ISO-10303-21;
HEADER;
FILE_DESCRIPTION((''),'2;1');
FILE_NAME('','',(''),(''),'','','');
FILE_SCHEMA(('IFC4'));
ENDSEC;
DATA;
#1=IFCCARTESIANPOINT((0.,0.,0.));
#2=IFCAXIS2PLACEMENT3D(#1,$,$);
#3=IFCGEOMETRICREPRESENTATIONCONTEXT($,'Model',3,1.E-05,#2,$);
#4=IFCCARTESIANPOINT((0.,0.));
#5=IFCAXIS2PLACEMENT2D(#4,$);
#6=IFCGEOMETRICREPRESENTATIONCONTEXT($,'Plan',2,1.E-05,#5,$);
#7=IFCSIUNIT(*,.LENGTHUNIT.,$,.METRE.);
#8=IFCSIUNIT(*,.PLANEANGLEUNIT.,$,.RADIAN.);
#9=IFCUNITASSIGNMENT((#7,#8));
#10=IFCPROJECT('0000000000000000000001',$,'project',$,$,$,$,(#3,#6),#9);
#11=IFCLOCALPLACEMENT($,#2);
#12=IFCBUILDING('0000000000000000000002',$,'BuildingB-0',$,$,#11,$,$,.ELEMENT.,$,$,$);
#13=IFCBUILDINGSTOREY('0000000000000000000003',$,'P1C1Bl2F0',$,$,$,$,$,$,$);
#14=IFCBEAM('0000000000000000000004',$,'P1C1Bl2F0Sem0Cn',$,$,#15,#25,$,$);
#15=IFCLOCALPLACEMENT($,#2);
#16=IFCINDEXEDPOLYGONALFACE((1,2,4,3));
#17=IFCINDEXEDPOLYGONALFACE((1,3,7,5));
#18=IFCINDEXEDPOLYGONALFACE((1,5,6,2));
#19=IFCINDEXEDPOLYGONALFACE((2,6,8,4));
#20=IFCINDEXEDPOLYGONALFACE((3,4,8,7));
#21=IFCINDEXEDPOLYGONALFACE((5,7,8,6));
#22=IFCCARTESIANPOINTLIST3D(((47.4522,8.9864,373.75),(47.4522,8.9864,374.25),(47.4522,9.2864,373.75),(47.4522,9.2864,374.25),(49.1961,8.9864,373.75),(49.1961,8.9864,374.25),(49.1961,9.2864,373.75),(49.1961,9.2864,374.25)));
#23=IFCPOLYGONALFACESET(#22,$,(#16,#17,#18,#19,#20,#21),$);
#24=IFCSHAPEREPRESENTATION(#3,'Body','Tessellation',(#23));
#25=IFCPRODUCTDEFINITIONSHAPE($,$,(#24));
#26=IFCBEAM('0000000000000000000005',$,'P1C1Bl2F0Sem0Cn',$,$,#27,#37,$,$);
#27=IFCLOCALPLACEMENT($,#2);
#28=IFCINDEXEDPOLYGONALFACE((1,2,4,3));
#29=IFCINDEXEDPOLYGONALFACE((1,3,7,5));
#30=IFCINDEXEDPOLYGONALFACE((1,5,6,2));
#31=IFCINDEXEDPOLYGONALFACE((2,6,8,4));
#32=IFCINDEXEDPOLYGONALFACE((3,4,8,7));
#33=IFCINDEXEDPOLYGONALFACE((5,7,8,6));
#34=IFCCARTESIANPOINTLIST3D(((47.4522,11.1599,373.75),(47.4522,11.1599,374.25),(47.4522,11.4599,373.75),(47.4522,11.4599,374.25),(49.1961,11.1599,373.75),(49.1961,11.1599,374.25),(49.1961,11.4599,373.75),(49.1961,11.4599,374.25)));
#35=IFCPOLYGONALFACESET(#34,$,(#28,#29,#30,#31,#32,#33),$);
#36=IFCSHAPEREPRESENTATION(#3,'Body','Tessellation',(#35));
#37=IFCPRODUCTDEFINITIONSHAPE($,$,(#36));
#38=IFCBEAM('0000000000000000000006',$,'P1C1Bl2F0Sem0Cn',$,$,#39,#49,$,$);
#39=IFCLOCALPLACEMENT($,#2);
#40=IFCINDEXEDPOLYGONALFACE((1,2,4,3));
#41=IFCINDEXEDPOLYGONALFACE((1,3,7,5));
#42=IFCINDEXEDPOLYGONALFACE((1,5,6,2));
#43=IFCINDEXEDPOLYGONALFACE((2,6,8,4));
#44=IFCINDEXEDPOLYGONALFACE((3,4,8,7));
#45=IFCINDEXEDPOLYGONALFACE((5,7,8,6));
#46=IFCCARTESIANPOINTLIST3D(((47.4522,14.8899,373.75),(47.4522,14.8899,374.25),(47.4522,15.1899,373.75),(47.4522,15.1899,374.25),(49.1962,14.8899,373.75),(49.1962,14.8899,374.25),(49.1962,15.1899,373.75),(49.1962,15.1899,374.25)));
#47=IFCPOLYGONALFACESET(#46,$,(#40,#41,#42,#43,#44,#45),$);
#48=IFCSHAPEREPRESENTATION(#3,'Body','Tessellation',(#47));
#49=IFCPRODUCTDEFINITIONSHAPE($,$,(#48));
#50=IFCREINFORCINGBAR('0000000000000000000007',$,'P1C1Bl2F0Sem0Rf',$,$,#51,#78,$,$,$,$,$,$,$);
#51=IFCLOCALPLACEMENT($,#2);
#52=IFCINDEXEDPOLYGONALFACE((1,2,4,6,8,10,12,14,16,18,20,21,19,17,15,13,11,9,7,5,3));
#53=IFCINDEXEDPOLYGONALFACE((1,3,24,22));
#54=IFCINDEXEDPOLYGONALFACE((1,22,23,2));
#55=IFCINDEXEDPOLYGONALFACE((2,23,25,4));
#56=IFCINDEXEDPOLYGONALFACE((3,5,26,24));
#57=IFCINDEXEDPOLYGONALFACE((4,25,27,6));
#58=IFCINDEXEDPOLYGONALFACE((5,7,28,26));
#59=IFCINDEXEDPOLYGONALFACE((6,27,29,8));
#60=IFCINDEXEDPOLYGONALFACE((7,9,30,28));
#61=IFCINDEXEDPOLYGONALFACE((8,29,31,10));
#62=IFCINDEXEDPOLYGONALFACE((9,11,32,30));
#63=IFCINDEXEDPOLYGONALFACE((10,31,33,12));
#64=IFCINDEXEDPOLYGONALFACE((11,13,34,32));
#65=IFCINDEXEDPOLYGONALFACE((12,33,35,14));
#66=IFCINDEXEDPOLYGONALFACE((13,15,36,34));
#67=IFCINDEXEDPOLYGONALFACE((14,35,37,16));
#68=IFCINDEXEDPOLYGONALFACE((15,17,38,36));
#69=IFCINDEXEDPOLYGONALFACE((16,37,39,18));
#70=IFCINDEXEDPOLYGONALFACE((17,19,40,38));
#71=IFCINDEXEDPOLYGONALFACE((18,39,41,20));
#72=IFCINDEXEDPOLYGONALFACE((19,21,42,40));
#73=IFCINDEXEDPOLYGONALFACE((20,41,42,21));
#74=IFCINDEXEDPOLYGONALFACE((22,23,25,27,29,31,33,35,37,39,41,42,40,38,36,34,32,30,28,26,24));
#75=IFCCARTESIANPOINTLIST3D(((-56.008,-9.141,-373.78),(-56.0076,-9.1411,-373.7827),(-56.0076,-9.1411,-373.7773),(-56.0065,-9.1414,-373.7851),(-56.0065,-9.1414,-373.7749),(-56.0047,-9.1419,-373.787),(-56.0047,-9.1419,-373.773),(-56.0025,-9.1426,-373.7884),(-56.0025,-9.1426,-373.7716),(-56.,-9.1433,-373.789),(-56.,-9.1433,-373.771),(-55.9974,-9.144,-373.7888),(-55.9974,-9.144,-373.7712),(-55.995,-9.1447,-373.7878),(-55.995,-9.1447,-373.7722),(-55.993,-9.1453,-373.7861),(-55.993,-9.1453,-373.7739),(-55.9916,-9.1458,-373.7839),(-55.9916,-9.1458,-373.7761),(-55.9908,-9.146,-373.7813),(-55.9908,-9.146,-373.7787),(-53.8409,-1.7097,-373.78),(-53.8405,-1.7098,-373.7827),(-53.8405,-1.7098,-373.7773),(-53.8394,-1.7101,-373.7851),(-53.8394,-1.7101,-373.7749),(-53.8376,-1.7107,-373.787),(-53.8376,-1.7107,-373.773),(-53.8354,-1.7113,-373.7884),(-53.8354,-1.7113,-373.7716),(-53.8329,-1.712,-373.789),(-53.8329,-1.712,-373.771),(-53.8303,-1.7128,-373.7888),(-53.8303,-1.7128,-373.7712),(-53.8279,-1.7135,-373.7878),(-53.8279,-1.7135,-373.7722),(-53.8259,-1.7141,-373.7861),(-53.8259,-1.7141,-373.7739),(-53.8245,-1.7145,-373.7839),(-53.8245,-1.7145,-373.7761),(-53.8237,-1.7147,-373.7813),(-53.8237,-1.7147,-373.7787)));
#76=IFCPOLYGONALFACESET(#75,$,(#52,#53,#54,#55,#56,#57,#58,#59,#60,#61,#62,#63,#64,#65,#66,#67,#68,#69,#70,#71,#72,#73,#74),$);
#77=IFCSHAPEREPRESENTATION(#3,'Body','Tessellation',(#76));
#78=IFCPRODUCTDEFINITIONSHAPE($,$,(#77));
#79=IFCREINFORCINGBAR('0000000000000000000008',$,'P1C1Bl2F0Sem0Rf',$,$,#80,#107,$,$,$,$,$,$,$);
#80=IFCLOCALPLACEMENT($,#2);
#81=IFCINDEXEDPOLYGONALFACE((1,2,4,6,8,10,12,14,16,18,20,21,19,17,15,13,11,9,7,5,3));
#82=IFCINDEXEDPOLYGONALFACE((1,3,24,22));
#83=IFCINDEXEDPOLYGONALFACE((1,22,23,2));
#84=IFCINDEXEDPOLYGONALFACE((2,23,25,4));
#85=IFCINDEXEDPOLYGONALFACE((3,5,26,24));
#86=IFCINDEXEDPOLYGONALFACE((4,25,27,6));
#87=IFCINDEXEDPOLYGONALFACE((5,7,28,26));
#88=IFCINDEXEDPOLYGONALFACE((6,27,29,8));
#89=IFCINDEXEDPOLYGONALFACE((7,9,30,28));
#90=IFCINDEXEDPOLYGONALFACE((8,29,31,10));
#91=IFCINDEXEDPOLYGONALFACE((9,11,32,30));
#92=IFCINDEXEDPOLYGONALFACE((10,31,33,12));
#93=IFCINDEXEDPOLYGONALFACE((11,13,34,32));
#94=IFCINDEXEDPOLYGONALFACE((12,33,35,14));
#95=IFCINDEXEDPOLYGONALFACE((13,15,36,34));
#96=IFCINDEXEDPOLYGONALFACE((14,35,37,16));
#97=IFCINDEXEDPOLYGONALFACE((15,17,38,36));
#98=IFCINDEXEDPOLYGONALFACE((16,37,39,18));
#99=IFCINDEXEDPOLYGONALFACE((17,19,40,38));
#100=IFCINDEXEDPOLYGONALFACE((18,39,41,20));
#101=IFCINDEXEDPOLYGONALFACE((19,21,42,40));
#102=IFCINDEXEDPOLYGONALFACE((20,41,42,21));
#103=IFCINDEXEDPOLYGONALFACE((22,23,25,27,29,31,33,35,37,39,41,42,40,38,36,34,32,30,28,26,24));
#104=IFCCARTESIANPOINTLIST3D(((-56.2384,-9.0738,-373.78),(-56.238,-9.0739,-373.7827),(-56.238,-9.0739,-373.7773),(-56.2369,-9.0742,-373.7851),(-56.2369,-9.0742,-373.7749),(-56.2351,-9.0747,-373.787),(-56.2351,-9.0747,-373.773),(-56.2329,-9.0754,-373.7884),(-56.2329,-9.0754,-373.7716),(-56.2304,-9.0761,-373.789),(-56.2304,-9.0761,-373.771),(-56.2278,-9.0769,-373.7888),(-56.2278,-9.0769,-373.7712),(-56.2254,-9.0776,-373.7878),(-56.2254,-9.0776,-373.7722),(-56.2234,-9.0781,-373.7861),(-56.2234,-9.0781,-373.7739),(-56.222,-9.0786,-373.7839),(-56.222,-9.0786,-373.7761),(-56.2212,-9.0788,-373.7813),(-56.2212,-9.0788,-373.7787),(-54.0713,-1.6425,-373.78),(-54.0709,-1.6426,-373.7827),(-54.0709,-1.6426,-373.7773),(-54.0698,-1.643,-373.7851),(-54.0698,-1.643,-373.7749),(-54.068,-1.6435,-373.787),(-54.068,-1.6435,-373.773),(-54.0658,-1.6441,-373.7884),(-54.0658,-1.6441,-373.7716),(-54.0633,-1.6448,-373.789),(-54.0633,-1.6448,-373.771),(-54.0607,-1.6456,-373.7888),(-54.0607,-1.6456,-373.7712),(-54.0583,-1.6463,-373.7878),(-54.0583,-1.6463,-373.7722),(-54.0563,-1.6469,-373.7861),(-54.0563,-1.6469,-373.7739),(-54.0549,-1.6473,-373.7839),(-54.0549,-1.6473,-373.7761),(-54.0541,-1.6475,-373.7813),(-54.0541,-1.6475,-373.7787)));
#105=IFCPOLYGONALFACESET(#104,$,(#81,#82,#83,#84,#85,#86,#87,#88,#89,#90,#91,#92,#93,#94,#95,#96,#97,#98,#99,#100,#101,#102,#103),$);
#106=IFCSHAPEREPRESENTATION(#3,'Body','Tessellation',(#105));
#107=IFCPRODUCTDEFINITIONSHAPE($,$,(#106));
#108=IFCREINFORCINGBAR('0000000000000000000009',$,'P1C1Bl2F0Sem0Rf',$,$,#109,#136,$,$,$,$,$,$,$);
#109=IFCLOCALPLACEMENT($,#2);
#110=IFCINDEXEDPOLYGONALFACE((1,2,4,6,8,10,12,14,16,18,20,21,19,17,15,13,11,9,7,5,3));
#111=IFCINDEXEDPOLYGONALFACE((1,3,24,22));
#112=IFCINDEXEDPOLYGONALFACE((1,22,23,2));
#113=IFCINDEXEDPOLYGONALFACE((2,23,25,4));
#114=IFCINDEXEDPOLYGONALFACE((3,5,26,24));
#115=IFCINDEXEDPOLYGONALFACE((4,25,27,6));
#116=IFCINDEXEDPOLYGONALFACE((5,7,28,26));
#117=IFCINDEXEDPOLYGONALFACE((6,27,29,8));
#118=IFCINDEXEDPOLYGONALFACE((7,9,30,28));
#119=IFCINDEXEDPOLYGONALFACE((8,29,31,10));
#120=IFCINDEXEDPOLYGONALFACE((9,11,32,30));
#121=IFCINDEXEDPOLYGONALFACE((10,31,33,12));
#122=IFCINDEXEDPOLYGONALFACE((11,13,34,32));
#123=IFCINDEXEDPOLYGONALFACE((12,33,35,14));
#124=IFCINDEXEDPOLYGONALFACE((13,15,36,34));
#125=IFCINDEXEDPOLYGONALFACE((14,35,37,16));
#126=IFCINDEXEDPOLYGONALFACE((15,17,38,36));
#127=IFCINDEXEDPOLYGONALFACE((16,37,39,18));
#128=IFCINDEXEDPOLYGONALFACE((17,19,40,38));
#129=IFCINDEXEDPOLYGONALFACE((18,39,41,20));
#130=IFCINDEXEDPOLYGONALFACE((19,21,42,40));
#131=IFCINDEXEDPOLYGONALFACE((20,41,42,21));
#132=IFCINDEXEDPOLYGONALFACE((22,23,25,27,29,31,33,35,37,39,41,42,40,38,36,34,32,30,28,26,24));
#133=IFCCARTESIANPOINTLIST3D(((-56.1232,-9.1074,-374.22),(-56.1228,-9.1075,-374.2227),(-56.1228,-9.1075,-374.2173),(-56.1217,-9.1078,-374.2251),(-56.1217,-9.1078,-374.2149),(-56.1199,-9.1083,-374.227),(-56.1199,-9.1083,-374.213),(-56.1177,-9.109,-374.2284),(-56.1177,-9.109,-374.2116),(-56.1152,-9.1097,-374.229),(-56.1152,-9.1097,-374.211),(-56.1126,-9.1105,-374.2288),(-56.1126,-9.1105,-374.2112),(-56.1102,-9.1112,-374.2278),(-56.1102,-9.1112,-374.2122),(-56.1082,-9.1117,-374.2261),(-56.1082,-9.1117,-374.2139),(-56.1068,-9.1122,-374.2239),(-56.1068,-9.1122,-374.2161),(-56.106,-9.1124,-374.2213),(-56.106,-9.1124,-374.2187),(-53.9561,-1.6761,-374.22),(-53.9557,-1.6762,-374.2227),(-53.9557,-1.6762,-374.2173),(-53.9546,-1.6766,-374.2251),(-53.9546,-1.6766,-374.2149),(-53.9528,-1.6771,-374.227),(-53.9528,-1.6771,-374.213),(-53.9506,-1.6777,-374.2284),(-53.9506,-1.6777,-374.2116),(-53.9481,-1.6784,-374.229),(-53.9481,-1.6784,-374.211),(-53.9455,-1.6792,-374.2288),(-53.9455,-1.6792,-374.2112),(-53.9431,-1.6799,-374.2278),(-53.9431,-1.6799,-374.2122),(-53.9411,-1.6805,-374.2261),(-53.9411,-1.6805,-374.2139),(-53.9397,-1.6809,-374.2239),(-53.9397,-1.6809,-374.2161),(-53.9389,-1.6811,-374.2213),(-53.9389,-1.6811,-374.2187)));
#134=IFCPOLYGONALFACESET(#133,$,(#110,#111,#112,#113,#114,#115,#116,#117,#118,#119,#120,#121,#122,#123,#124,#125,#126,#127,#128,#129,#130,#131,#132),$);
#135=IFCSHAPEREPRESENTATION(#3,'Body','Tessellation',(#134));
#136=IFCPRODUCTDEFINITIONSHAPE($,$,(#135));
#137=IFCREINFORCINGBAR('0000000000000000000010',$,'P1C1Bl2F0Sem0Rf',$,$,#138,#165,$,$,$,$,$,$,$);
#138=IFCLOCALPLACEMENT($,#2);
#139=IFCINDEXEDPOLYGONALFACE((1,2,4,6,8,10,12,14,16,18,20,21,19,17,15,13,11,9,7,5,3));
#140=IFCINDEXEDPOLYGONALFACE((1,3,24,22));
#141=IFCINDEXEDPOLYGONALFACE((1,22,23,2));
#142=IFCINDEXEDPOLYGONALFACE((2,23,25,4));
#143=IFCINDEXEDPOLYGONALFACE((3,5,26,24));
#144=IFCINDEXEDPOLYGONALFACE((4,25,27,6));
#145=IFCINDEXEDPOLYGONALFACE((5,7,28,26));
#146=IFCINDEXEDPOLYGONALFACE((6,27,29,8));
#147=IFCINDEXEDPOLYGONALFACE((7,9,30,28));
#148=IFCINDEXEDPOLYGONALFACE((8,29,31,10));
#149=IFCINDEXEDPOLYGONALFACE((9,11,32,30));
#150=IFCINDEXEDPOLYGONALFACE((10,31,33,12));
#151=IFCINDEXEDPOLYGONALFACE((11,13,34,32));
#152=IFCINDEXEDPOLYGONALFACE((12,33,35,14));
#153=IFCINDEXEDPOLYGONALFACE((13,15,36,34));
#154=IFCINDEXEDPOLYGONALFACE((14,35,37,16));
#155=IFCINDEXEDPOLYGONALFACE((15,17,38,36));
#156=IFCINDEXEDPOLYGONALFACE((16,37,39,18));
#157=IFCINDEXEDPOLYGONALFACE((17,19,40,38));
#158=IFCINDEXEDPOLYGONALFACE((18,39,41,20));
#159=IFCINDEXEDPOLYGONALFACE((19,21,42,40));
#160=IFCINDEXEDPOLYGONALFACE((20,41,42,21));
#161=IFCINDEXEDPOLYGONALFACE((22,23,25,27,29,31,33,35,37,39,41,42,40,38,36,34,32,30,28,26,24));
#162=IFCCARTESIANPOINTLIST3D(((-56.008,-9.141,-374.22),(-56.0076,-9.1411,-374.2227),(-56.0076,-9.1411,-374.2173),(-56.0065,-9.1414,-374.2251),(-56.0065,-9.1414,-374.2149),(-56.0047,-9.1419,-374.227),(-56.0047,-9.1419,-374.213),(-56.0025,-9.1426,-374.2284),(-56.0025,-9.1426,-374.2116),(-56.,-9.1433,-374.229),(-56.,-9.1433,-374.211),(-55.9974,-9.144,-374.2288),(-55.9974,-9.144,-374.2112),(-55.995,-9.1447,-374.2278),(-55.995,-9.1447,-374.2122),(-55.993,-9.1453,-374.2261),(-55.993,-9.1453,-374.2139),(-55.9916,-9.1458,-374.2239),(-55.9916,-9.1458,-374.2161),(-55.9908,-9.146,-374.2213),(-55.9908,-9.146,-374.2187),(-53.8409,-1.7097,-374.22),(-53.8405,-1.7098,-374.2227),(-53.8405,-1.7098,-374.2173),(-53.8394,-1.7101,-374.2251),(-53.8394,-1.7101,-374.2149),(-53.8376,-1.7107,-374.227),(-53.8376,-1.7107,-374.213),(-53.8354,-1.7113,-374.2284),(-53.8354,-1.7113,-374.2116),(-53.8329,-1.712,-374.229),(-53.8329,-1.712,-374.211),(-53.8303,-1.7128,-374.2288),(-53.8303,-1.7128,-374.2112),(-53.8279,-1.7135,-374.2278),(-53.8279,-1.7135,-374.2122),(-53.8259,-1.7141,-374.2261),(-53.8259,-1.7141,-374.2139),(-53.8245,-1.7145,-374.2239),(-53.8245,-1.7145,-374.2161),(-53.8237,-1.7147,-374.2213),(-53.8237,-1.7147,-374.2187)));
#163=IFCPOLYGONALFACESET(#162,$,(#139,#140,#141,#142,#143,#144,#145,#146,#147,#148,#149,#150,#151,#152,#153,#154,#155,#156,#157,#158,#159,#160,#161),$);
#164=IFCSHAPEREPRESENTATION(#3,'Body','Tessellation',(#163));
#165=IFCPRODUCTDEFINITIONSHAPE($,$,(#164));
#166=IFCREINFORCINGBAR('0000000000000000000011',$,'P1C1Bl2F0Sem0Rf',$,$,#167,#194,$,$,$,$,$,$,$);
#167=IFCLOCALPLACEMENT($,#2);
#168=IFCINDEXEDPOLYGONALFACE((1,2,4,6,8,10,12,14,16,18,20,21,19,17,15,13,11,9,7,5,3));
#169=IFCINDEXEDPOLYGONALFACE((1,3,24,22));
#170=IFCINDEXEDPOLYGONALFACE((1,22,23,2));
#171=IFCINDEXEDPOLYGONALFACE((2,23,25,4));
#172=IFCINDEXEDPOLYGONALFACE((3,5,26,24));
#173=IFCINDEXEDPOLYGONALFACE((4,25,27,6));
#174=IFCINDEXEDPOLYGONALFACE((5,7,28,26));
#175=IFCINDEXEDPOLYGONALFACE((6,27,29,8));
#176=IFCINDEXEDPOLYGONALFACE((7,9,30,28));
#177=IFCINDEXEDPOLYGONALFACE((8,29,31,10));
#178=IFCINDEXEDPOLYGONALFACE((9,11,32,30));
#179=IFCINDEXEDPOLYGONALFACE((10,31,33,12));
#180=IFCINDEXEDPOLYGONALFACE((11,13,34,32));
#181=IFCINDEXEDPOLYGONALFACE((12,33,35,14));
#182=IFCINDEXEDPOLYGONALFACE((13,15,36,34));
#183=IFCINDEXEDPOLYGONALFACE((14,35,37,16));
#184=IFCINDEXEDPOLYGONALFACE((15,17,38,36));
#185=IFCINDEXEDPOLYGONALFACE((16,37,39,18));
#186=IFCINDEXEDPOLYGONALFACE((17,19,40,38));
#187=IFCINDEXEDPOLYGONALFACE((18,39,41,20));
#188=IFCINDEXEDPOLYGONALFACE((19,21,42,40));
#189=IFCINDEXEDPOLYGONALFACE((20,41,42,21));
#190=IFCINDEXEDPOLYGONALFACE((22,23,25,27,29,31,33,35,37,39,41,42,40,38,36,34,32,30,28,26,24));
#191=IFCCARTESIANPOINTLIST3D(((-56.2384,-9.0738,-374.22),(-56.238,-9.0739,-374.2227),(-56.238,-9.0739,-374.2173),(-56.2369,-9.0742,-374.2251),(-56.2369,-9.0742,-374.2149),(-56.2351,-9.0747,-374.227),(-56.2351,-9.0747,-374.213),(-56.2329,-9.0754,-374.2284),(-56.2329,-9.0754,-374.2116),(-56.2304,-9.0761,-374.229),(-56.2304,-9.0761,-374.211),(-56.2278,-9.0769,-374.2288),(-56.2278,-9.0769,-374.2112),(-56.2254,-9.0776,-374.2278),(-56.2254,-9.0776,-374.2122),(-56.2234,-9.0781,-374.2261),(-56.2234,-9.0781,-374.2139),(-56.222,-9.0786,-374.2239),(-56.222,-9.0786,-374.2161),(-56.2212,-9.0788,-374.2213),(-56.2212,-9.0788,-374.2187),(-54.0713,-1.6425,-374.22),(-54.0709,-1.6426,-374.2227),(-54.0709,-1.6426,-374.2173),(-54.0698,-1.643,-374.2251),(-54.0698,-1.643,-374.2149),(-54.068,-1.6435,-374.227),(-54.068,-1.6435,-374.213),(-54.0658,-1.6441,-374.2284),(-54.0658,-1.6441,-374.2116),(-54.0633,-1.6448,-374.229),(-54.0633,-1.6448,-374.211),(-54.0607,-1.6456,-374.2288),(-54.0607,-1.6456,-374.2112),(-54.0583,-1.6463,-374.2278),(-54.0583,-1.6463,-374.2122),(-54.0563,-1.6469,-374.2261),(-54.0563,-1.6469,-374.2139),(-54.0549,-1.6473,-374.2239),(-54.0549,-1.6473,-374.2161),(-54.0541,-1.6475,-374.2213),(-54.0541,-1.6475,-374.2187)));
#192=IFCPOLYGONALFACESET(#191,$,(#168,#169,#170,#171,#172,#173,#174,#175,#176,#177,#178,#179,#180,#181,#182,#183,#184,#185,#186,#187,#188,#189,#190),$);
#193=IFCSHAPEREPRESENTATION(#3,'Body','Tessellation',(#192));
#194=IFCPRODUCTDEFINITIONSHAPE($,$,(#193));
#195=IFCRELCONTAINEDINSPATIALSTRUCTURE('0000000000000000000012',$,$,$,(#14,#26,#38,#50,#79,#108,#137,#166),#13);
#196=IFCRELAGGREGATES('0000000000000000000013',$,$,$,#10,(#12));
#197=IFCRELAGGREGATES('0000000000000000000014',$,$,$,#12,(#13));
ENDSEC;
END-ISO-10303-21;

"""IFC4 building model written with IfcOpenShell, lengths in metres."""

from ifc_helpers import new_model, entity, si_unit, origin, origin_2d, place, context, project, spatial, polyline, outline, extrude, element, save


model = new_model("IFC4")

# Units and contexts
model_context = context("Model", 3, precision=1e-05, world=origin())
plan_context = context("Plan", 2, precision=1e-05, world=origin_2d())
ifc_project = project(units=[si_unit("LENGTHUNIT", "METRE"), si_unit("PLANEANGLEUNIT", "RADIAN")], contexts=[model_context, plan_context])

# Building, storey
building_placement = place(None, origin())
building = spatial("IfcBuilding", under=ifc_project, at=building_placement, Name="BuildingB-0", CompositionType="ELEMENT")
storey = spatial("IfcBuildingStorey", under=building, Name="P1C1Bl2F0")

# Beams
element("IfcBeam", 1, inside=storey, Name="P1C1Bl2F0Sem0Cn", context=model_context, shape_type="SweptSolid", body=[
    extrude(outline(polyline([(47.4522, 8.9864, 373.75), (49.1961, 8.9864, 373.75), (49.1961, 9.2864, 373.75), (47.4522, 9.2864, 373.75), (47.4522, 8.9864, 373.75)])), None, (0.0, 0.0, 1.0), 0.5),
])
element("IfcBeam", 2, inside=storey, Name="P1C1Bl2F0Sem0Cn", context=model_context, shape_type="SweptSolid", body=[
    extrude(outline(polyline([(47.4522, 11.1599, 373.75), (47.4522, 11.4599, 373.75), (49.1961, 11.4599, 373.75), (49.1961, 11.1599, 373.75), (47.4522, 11.1599, 373.75)])), None, (0.0, 0.0, 1.0), 0.5),
])
element("IfcBeam", 3, inside=storey, Name="P1C1Bl2F0Sem0Cn", context=model_context, shape_type="SweptSolid", body=[
    extrude(outline(polyline([(47.4522, 14.8899, 373.75), (47.4522, 15.1899, 373.75), (49.1962, 15.1899, 373.75), (49.1962, 14.8899, 373.75), (47.4522, 14.8899, 373.75)])), None, (0.0, 0.0, 1.0), 0.5),
])

# Reinforcing bars
element("IfcReinforcingBar", 4, inside=storey, Name="P1C1Bl2F0Sem0Rf", context=model_context, shape_type="SweptSolid", body=[
    entity("IfcSurfaceCurveSweptAreaSolid", entity("IfcCircleProfileDef", "AREA", None, None, 0.009), None, entity("IfcPolyline", [entity("IfcCartesianPoint", [55.9993, 9.1435, 373.78]), entity("IfcCartesianPoint", [53.8323, 1.7122, 373.78])]), None, None, entity("IfcPlane", entity("IfcAxis2Placement3D", entity("IfcCartesianPoint", [55.9993, 9.1435, 373.78]), entity("IfcDirection", [0.0, 0.0, 1.0]), entity("IfcDirection", [1.0, 0.0, 0.0])))),
])
element("IfcReinforcingBar", 5, inside=storey, Name="P1C1Bl2F0Sem0Rf", context=model_context, shape_type="SweptSolid", body=[
    entity("IfcSurfaceCurveSweptAreaSolid", entity("IfcCircleProfileDef", "AREA", None, None, 0.009), None, entity("IfcPolyline", [entity("IfcCartesianPoint", [56.2298, 9.0763, 373.78]), entity("IfcCartesianPoint", [54.0627, 1.645, 373.78])]), None, None, entity("IfcPlane", entity("IfcAxis2Placement3D", entity("IfcCartesianPoint", [56.2298, 9.0763, 373.78]), entity("IfcDirection", [0.0, 0.0, 1.0]), entity("IfcDirection", [1.0, 0.0, 0.0])))),
])
element("IfcReinforcingBar", 6, inside=storey, Name="P1C1Bl2F0Sem0Rf", context=model_context, shape_type="SweptSolid", body=[
    entity("IfcSurfaceCurveSweptAreaSolid", entity("IfcCircleProfileDef", "AREA", None, None, 0.009), None, entity("IfcPolyline", [entity("IfcCartesianPoint", [56.1146, 9.1099, 374.22]), entity("IfcCartesianPoint", [53.9475, 1.6786, 374.22])]), None, None, entity("IfcPlane", entity("IfcAxis2Placement3D", entity("IfcCartesianPoint", [56.1146, 9.1099, 374.22]), entity("IfcDirection", [0.0, 0.0, 1.0]), entity("IfcDirection", [1.0, 0.0, 0.0])))),
])
element("IfcReinforcingBar", 7, inside=storey, Name="P1C1Bl2F0Sem0Rf", context=model_context, shape_type="SweptSolid", body=[
    entity("IfcSurfaceCurveSweptAreaSolid", entity("IfcCircleProfileDef", "AREA", None, None, 0.009), None, entity("IfcPolyline", [entity("IfcCartesianPoint", [55.9993, 9.1435, 374.22]), entity("IfcCartesianPoint", [53.8323, 1.7122, 374.22])]), None, None, entity("IfcPlane", entity("IfcAxis2Placement3D", entity("IfcCartesianPoint", [55.9993, 9.1435, 374.22]), entity("IfcDirection", [0.0, 0.0, 1.0]), entity("IfcDirection", [1.0, 0.0, 0.0])))),
])
element("IfcReinforcingBar", 8, inside=storey, Name="P1C1Bl2F0Sem0Rf", context=model_context, shape_type="SweptSolid", body=[
    entity("IfcSurfaceCurveSweptAreaSolid", entity("IfcCircleProfileDef", "AREA", None, None, 0.009), None, entity("IfcPolyline", [entity("IfcCartesianPoint", [56.2298, 9.0763, 374.22]), entity("IfcCartesianPoint", [54.0627, 1.645, 374.22])]), None, None, entity("IfcPlane", entity("IfcAxis2Placement3D", entity("IfcCartesianPoint", [56.2298, 9.0763, 374.22]), entity("IfcDirection", [0.0, 0.0, 1.0]), entity("IfcDirection", [1.0, 0.0, 0.0])))),
])

save(model, "model.ifc")
